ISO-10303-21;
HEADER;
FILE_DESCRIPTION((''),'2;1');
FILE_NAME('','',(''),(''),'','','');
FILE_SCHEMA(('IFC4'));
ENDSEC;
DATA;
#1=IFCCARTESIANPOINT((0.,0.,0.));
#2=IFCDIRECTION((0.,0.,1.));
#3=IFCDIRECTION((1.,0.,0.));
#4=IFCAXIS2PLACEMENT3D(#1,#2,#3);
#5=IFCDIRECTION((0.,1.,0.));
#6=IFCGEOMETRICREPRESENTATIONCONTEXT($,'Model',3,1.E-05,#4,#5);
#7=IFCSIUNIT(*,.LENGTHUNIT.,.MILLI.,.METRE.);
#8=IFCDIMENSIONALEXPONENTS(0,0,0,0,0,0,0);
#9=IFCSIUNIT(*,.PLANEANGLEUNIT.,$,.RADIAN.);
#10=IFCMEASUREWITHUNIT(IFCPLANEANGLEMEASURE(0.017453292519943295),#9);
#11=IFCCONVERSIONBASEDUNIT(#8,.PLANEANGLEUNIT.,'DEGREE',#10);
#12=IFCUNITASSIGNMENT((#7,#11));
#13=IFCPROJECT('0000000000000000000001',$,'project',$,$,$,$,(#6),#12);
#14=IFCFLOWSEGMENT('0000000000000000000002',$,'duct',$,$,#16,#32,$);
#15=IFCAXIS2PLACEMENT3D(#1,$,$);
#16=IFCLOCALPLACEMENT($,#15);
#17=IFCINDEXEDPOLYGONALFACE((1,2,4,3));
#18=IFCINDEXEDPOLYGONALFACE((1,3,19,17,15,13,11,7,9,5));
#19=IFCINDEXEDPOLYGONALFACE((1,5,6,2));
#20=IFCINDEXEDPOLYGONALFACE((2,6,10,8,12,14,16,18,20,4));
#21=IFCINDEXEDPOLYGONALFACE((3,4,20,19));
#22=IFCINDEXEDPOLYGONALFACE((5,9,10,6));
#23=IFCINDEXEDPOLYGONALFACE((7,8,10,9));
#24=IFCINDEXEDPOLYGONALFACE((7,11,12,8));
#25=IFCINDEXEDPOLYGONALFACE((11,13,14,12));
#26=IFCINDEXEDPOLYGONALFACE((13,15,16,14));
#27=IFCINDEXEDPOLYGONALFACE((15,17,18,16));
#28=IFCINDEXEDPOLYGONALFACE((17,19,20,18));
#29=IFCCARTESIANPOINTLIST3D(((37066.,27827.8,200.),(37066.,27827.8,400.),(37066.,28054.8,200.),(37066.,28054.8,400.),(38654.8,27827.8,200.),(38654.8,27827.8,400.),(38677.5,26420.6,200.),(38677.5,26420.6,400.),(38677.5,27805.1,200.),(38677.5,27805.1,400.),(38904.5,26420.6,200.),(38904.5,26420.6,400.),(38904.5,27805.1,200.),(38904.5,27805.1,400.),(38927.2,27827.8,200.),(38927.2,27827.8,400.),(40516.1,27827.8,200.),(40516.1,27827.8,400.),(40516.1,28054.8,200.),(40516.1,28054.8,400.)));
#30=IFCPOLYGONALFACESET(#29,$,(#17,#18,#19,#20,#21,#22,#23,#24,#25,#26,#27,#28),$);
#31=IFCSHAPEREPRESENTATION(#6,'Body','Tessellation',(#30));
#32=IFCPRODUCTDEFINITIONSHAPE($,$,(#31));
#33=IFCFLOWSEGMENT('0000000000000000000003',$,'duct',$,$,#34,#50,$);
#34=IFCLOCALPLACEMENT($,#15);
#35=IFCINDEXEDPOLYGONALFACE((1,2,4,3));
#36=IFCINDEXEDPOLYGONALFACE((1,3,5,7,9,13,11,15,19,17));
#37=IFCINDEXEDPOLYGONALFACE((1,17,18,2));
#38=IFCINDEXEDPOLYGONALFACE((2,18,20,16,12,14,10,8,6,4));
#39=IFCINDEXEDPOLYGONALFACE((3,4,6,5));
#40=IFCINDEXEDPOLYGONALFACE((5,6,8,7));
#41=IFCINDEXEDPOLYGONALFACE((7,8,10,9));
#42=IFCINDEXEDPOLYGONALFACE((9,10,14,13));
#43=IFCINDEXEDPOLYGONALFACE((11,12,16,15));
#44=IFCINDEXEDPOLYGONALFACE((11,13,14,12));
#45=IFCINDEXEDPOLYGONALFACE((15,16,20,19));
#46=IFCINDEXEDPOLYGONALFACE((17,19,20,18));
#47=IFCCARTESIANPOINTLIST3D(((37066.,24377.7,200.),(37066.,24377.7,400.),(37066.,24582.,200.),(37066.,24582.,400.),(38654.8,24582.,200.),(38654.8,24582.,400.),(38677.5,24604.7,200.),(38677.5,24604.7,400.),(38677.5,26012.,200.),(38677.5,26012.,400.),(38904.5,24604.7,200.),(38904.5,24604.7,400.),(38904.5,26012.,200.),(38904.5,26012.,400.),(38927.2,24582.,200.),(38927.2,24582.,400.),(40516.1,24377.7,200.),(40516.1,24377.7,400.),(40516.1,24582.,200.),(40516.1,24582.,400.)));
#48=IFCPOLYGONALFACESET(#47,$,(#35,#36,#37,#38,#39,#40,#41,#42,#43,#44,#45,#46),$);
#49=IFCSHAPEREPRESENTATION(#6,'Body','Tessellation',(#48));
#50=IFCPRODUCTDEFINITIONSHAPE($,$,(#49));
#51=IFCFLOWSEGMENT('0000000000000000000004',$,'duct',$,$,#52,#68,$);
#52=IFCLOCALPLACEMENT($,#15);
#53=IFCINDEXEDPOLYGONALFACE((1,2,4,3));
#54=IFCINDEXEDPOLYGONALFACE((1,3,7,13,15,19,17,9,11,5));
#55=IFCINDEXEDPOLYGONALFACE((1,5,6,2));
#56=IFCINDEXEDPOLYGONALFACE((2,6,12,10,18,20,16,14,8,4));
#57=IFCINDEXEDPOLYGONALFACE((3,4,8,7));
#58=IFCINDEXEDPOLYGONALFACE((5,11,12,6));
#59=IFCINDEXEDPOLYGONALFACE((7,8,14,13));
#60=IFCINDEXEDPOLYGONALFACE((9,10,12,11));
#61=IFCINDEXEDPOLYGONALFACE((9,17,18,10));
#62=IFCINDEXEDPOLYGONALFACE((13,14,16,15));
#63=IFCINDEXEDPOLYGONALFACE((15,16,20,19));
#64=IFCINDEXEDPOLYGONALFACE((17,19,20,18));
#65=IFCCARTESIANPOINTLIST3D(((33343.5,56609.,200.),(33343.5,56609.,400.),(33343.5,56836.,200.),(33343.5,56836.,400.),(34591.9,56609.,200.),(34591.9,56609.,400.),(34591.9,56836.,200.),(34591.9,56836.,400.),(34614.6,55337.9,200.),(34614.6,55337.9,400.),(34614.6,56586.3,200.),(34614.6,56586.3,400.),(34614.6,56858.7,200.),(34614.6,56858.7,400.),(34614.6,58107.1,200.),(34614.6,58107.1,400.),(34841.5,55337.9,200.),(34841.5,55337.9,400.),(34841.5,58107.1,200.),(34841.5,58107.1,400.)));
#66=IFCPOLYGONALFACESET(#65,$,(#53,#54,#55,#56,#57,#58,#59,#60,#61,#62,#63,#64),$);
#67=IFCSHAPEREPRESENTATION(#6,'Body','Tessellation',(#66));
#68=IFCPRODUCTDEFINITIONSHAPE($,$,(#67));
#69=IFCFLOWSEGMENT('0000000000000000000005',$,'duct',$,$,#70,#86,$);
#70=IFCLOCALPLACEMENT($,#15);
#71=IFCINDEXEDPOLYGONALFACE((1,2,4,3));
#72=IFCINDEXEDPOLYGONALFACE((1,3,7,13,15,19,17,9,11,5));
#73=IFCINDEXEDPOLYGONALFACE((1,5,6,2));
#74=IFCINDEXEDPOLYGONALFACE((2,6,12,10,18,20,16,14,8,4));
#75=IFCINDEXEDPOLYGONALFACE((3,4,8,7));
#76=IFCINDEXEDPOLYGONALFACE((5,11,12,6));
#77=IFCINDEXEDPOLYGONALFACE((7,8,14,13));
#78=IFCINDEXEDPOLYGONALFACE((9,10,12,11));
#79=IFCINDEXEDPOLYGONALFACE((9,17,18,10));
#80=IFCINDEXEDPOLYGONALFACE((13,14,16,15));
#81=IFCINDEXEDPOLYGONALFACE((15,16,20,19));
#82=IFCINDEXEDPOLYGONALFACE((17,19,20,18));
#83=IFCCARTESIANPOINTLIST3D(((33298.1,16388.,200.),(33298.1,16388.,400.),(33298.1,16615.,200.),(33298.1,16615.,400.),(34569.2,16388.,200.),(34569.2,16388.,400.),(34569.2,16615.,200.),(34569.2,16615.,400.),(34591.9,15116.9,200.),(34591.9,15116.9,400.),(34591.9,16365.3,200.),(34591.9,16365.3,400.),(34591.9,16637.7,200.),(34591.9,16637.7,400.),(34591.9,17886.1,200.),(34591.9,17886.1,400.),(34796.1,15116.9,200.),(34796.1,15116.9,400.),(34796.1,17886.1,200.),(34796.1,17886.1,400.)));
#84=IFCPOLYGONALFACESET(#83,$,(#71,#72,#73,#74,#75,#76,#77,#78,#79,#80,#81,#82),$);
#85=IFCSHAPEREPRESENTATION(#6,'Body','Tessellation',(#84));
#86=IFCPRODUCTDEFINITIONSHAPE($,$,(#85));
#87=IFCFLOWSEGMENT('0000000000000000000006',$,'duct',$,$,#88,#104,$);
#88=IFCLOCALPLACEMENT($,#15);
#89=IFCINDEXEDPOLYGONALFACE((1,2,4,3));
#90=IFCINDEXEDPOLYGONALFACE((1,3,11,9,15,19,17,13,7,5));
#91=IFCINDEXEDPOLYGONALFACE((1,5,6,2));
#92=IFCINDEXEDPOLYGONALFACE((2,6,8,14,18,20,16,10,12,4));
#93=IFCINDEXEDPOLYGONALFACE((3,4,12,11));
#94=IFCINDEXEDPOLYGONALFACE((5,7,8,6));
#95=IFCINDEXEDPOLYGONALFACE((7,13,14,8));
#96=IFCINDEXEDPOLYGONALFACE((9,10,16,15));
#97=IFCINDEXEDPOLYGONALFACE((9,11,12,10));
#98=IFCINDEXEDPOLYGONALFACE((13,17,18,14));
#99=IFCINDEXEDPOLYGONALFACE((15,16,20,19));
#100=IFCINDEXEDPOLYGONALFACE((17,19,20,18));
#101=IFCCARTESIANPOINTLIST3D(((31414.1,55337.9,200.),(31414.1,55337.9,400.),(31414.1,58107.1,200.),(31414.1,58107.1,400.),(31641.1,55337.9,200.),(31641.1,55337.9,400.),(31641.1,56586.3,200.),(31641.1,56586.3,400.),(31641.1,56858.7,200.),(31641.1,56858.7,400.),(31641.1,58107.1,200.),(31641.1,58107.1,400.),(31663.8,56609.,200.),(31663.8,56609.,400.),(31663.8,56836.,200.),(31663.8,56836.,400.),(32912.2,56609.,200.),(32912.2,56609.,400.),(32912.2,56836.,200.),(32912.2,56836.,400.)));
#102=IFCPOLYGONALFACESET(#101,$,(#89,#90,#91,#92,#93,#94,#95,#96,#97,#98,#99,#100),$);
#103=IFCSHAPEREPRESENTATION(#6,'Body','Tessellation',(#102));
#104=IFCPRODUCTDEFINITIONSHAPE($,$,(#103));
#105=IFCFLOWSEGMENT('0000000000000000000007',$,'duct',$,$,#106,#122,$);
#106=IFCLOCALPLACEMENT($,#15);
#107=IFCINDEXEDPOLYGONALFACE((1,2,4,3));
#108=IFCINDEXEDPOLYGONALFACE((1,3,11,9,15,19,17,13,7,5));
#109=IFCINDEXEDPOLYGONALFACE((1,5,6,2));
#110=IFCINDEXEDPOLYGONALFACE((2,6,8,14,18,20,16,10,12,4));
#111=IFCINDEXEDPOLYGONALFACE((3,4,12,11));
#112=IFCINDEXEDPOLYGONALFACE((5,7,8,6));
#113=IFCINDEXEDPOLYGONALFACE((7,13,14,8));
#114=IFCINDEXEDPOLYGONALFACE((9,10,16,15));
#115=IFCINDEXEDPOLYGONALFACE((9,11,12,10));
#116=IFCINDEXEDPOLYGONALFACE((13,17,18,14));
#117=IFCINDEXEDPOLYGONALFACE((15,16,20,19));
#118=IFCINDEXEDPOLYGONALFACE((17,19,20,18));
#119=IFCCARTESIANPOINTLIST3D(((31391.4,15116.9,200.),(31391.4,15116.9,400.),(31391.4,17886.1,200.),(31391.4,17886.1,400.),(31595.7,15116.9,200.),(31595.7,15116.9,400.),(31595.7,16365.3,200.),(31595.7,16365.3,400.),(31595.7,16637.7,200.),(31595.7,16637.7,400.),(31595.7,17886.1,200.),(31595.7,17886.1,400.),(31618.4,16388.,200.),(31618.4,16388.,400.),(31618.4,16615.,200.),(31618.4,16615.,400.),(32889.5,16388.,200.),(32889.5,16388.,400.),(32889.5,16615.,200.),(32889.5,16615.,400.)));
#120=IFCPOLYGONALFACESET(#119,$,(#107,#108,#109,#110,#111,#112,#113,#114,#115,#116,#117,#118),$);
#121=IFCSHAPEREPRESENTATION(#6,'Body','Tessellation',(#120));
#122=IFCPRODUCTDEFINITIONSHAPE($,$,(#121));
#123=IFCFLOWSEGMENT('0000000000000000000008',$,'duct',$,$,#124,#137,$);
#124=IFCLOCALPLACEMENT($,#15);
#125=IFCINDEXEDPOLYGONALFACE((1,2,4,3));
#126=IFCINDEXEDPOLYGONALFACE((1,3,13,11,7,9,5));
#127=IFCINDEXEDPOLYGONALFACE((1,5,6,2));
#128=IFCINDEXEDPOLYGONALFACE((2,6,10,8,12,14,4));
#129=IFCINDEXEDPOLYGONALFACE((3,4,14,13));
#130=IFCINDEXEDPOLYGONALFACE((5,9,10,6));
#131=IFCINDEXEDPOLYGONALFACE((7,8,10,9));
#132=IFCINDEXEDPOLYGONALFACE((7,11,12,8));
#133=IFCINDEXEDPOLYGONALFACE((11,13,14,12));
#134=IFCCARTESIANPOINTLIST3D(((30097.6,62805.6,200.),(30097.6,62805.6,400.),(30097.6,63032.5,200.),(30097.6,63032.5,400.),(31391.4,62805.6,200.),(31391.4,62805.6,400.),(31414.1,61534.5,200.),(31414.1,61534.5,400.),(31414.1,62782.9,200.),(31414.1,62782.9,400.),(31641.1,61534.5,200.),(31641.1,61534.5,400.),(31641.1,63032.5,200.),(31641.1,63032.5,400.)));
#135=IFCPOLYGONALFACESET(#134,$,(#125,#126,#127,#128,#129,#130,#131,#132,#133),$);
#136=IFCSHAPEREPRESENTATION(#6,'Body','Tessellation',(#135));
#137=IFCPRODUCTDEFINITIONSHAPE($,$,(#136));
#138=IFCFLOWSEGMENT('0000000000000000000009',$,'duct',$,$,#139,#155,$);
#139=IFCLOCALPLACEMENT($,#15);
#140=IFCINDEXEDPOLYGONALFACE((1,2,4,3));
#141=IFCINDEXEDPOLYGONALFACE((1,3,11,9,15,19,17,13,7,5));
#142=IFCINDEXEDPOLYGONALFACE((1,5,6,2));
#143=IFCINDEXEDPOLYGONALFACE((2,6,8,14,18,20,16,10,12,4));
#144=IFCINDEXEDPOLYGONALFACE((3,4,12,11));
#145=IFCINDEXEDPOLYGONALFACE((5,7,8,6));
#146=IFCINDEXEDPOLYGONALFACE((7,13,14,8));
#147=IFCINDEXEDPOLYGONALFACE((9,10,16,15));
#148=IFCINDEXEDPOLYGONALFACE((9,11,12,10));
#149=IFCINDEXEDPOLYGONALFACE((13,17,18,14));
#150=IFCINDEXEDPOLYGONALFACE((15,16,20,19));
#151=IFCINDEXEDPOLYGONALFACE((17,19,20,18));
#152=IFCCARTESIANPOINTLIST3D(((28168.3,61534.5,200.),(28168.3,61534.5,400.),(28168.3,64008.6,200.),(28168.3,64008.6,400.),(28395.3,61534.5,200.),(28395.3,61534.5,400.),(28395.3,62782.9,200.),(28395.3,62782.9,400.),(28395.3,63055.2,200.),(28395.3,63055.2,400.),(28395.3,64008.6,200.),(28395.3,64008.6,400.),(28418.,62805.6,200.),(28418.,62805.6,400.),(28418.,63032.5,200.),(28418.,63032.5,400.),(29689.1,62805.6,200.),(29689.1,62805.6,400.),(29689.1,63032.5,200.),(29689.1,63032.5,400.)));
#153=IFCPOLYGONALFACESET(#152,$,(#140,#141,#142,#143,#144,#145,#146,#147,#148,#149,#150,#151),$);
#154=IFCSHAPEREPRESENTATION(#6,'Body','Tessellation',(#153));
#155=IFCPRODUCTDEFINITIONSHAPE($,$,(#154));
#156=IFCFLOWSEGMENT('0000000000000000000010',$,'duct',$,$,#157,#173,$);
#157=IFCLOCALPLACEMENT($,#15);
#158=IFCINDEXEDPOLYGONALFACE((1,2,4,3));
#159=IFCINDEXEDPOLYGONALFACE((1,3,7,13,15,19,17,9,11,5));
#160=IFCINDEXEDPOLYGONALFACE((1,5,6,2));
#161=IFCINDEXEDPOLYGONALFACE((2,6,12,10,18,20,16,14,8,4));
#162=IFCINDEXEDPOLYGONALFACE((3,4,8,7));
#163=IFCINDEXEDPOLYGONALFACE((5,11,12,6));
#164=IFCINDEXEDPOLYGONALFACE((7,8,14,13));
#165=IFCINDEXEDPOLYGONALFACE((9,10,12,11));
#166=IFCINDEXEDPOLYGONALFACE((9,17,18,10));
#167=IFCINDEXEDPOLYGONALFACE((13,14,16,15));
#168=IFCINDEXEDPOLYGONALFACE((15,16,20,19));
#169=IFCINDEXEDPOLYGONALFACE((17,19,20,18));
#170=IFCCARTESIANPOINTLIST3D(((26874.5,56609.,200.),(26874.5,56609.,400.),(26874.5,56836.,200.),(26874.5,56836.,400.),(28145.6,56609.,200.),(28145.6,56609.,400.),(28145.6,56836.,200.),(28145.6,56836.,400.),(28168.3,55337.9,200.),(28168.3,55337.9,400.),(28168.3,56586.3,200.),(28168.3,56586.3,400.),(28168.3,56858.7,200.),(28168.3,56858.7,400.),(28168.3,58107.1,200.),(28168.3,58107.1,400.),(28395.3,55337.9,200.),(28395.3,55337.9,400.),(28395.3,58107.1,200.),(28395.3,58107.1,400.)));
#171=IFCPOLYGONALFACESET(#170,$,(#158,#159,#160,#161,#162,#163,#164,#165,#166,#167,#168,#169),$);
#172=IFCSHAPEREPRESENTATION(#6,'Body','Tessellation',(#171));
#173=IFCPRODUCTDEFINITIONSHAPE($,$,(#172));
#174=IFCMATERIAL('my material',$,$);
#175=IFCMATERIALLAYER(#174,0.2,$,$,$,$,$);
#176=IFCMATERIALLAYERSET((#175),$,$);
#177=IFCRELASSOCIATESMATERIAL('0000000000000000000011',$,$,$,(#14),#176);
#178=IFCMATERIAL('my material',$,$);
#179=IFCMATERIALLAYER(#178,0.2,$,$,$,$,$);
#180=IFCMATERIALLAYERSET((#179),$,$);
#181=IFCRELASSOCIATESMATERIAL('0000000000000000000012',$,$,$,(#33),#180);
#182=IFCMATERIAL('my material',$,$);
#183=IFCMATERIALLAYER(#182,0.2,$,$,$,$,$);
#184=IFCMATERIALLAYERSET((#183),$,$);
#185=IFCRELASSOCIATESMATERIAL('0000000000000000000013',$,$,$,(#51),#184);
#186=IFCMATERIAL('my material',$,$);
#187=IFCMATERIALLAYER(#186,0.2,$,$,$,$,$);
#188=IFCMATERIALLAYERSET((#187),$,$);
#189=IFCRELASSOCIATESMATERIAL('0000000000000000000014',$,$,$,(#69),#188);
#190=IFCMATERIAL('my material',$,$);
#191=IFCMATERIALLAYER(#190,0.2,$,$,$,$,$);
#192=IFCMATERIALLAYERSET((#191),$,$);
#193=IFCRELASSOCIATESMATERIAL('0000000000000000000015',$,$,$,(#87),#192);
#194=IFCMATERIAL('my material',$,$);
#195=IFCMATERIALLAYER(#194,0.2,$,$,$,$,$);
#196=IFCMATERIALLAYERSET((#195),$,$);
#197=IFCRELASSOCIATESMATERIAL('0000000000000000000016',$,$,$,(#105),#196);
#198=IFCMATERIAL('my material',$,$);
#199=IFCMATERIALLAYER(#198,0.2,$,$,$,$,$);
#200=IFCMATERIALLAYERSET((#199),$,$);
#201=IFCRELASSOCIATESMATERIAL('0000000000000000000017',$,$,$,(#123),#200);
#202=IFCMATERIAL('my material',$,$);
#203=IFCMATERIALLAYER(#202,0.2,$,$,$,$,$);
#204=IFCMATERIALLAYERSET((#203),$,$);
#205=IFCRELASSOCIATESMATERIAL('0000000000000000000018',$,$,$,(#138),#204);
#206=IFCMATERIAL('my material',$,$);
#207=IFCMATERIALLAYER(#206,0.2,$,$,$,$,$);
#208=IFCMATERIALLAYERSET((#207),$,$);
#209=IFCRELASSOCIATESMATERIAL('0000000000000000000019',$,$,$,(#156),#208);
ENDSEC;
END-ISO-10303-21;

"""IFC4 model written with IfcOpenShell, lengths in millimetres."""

from ifc_helpers import new_model, entity, si_unit, converted_unit, direction, frame, origin_with_axes, place, context, project, polyline, outline, extrude, material, layer, layer_set, layer_usage, element, save


model = new_model("IFC4")

# Units and contexts
model_context = context("Model", 3, precision=1e-05, world=origin_with_axes(), true_north=direction((0.0, 1.0, 0.0)))
ifc_project = project(units=[si_unit("LENGTHUNIT", "METRE", prefix="MILLI"), converted_unit("PLANEANGLEUNIT", "DEGREE", entity("IfcPlaneAngleMeasure", 0.017453292519943295), si_unit("PLANEANGLEUNIT", "RADIAN"), dimensions=[0, 0, 0, 0, 0, 0, 0])], contexts=[model_context])

# Flow segments
ifc_material_1 = material(Name="my material")
ifc_layer_1 = layer(ifc_material_1, 0.2)
ifc_layer_set_1 = layer_set([ifc_layer_1])
ifc_layer_usage_1 = layer_usage(ifc_layer_set_1, "AXIS2", "POSITIVE", -0.1)
flow_segment_1_placement = place(None, origin_with_axes())
element("IfcFlowSegment", 1, at=flow_segment_1_placement, material=ifc_layer_usage_1, Name="duct", context=model_context, shape_type="SweptSolid", body=[
    extrude(outline(polyline([(37066.0, 27827.8), (38654.8, 27827.8), (38677.5, 27805.1), (38677.5, 26420.6), (38904.5, 26420.6), (38904.5, 27805.1), (38927.2, 27827.8), (40516.1, 27827.8), (40516.1, 28054.8), (37066.0, 28054.8), (37066.0, 27827.8)])), frame((0.0, 0.0, 200.0), z_axis=(0.0, 0.0, 1.0), x_axis=(1.0, 0.0, 0.0)), (0.0, 0.0, 1.0), 200.0),
])
ifc_material_2 = material(Name="my material")
ifc_layer_2 = layer(ifc_material_2, 0.2)
ifc_layer_set_2 = layer_set([ifc_layer_2])
ifc_layer_usage_2 = layer_usage(ifc_layer_set_2, "AXIS2", "POSITIVE", -0.1)
flow_segment_2_placement = place(None, origin_with_axes())
element("IfcFlowSegment", 2, at=flow_segment_2_placement, material=ifc_layer_usage_2, Name="duct", context=model_context, shape_type="SweptSolid", body=[
    extrude(outline(polyline([(37066.0, 24377.7), (40516.1, 24377.7), (40516.1, 24582.0), (38927.2, 24582.0), (38904.5, 24604.7), (38904.5, 26012.0), (38677.5, 26012.0), (38677.5, 24604.7), (38654.8, 24582.0), (37066.0, 24582.0), (37066.0, 24377.7)])), frame((0.0, 0.0, 200.0), z_axis=(0.0, 0.0, 1.0), x_axis=(1.0, 0.0, 0.0)), (0.0, 0.0, 1.0), 200.0),
])
ifc_material_3 = material(Name="my material")
ifc_layer_3 = layer(ifc_material_3, 0.2)
ifc_layer_set_3 = layer_set([ifc_layer_3])
ifc_layer_usage_3 = layer_usage(ifc_layer_set_3, "AXIS2", "POSITIVE", -0.1)
flow_segment_3_placement = place(None, origin_with_axes())
element("IfcFlowSegment", 3, at=flow_segment_3_placement, material=ifc_layer_usage_3, Name="duct", context=model_context, shape_type="SweptSolid", body=[
    extrude(outline(polyline([(33343.5, 56609.0), (34591.9, 56609.0), (34614.6, 56586.3), (34614.6, 55337.9), (34841.5, 55337.9), (34841.5, 58107.1), (34614.6, 58107.1), (34614.6, 56858.7), (34591.9, 56836.0), (33343.5, 56836.0), (33343.5, 56609.0)])), frame((0.0, 0.0, 200.0), z_axis=(0.0, 0.0, 1.0), x_axis=(1.0, 0.0, 0.0)), (0.0, 0.0, 1.0), 200.0),
])
ifc_material_4 = material(Name="my material")
ifc_layer_4 = layer(ifc_material_4, 0.2)
ifc_layer_set_4 = layer_set([ifc_layer_4])
ifc_layer_usage_4 = layer_usage(ifc_layer_set_4, "AXIS2", "POSITIVE", -0.1)
flow_segment_4_placement = place(None, origin_with_axes())
element("IfcFlowSegment", 4, at=flow_segment_4_placement, material=ifc_layer_usage_4, Name="duct", context=model_context, shape_type="SweptSolid", body=[
    extrude(outline(polyline([(33298.1, 16388.0), (34569.2, 16388.0), (34591.9, 16365.3), (34591.9, 15116.9), (34796.1, 15116.9), (34796.1, 17886.1), (34591.9, 17886.1), (34591.9, 16637.7), (34569.2, 16615.0), (33298.1, 16615.0), (33298.1, 16388.0)])), frame((0.0, 0.0, 200.0), z_axis=(0.0, 0.0, 1.0), x_axis=(1.0, 0.0, 0.0)), (0.0, 0.0, 1.0), 200.0),
])
ifc_material_5 = material(Name="my material")
ifc_layer_5 = layer(ifc_material_5, 0.2)
ifc_layer_set_5 = layer_set([ifc_layer_5])
ifc_layer_usage_5 = layer_usage(ifc_layer_set_5, "AXIS2", "POSITIVE", -0.1)
flow_segment_5_placement = place(None, origin_with_axes())
element("IfcFlowSegment", 5, at=flow_segment_5_placement, material=ifc_layer_usage_5, Name="duct", context=model_context, shape_type="SweptSolid", body=[
    extrude(outline(polyline([(31414.1, 55337.9), (31641.1, 55337.9), (31641.1, 56586.3), (31663.8, 56609.0), (32912.2, 56609.0), (32912.2, 56836.0), (31663.8, 56836.0), (31641.1, 56858.7), (31641.1, 58107.1), (31414.1, 58107.1), (31414.1, 55337.9)])), frame((0.0, 0.0, 200.0), z_axis=(0.0, 0.0, 1.0), x_axis=(1.0, 0.0, 0.0)), (0.0, 0.0, 1.0), 200.0),
])
ifc_material_6 = material(Name="my material")
ifc_layer_6 = layer(ifc_material_6, 0.2)
ifc_layer_set_6 = layer_set([ifc_layer_6])
ifc_layer_usage_6 = layer_usage(ifc_layer_set_6, "AXIS2", "POSITIVE", -0.1)
flow_segment_6_placement = place(None, origin_with_axes())
element("IfcFlowSegment", 6, at=flow_segment_6_placement, material=ifc_layer_usage_6, Name="duct", context=model_context, shape_type="SweptSolid", body=[
    extrude(outline(polyline([(31391.4, 15116.9), (31595.7, 15116.9), (31595.7, 16365.3), (31618.4, 16388.0), (32889.5, 16388.0), (32889.5, 16615.0), (31618.4, 16615.0), (31595.7, 16637.7), (31595.7, 17886.1), (31391.4, 17886.1), (31391.4, 15116.9)])), frame((0.0, 0.0, 200.0), z_axis=(0.0, 0.0, 1.0), x_axis=(1.0, 0.0, 0.0)), (0.0, 0.0, 1.0), 200.0),
])
ifc_material_7 = material(Name="my material")
ifc_layer_7 = layer(ifc_material_7, 0.2)
ifc_layer_set_7 = layer_set([ifc_layer_7])
ifc_layer_usage_7 = layer_usage(ifc_layer_set_7, "AXIS2", "POSITIVE", -0.1)
flow_segment_7_placement = place(None, origin_with_axes())
element("IfcFlowSegment", 7, at=flow_segment_7_placement, material=ifc_layer_usage_7, Name="duct", context=model_context, shape_type="SweptSolid", body=[
    extrude(outline(polyline([(30097.6, 62805.6), (31391.4, 62805.6), (31414.1, 62782.9), (31414.1, 61534.5), (31641.1, 61534.5), (31641.1, 63032.5), (30097.6, 63032.5), (30097.6, 62805.6)])), frame((0.0, 0.0, 200.0), z_axis=(0.0, 0.0, 1.0), x_axis=(1.0, 0.0, 0.0)), (0.0, 0.0, 1.0), 200.0),
])
ifc_material_8 = material(Name="my material")
ifc_layer_8 = layer(ifc_material_8, 0.2)
ifc_layer_set_8 = layer_set([ifc_layer_8])
ifc_layer_usage_8 = layer_usage(ifc_layer_set_8, "AXIS2", "POSITIVE", -0.1)
flow_segment_8_placement = place(None, origin_with_axes())
element("IfcFlowSegment", 8, at=flow_segment_8_placement, material=ifc_layer_usage_8, Name="duct", context=model_context, shape_type="SweptSolid", body=[
    extrude(outline(polyline([(28168.3, 61534.5), (28395.3, 61534.5), (28395.3, 62782.9), (28418.0, 62805.6), (29689.1, 62805.6), (29689.1, 63032.5), (28418.0, 63032.5), (28395.3, 63055.2), (28395.3, 64008.6), (28168.3, 64008.6), (28168.3, 61534.5)])), frame((0.0, 0.0, 200.0), z_axis=(0.0, 0.0, 1.0), x_axis=(1.0, 0.0, 0.0)), (0.0, 0.0, 1.0), 200.0),
])
ifc_material_9 = material(Name="my material")
ifc_layer_9 = layer(ifc_material_9, 0.2)
ifc_layer_set_9 = layer_set([ifc_layer_9])
ifc_layer_usage_9 = layer_usage(ifc_layer_set_9, "AXIS2", "POSITIVE", -0.1)
flow_segment_9_placement = place(None, origin_with_axes())
element("IfcFlowSegment", 9, at=flow_segment_9_placement, material=ifc_layer_usage_9, Name="duct", context=model_context, shape_type="SweptSolid", body=[
    extrude(outline(polyline([(26874.5, 56609.0), (28145.6, 56609.0), (28168.3, 56586.3), (28168.3, 55337.9), (28395.3, 55337.9), (28395.3, 58107.1), (28168.3, 58107.1), (28168.3, 56858.7), (28145.6, 56836.0), (26874.5, 56836.0), (26874.5, 56609.0)])), frame((0.0, 0.0, 200.0), z_axis=(0.0, 0.0, 1.0), x_axis=(1.0, 0.0, 0.0)), (0.0, 0.0, 1.0), 200.0),
])

save(model, "model.ifc")
